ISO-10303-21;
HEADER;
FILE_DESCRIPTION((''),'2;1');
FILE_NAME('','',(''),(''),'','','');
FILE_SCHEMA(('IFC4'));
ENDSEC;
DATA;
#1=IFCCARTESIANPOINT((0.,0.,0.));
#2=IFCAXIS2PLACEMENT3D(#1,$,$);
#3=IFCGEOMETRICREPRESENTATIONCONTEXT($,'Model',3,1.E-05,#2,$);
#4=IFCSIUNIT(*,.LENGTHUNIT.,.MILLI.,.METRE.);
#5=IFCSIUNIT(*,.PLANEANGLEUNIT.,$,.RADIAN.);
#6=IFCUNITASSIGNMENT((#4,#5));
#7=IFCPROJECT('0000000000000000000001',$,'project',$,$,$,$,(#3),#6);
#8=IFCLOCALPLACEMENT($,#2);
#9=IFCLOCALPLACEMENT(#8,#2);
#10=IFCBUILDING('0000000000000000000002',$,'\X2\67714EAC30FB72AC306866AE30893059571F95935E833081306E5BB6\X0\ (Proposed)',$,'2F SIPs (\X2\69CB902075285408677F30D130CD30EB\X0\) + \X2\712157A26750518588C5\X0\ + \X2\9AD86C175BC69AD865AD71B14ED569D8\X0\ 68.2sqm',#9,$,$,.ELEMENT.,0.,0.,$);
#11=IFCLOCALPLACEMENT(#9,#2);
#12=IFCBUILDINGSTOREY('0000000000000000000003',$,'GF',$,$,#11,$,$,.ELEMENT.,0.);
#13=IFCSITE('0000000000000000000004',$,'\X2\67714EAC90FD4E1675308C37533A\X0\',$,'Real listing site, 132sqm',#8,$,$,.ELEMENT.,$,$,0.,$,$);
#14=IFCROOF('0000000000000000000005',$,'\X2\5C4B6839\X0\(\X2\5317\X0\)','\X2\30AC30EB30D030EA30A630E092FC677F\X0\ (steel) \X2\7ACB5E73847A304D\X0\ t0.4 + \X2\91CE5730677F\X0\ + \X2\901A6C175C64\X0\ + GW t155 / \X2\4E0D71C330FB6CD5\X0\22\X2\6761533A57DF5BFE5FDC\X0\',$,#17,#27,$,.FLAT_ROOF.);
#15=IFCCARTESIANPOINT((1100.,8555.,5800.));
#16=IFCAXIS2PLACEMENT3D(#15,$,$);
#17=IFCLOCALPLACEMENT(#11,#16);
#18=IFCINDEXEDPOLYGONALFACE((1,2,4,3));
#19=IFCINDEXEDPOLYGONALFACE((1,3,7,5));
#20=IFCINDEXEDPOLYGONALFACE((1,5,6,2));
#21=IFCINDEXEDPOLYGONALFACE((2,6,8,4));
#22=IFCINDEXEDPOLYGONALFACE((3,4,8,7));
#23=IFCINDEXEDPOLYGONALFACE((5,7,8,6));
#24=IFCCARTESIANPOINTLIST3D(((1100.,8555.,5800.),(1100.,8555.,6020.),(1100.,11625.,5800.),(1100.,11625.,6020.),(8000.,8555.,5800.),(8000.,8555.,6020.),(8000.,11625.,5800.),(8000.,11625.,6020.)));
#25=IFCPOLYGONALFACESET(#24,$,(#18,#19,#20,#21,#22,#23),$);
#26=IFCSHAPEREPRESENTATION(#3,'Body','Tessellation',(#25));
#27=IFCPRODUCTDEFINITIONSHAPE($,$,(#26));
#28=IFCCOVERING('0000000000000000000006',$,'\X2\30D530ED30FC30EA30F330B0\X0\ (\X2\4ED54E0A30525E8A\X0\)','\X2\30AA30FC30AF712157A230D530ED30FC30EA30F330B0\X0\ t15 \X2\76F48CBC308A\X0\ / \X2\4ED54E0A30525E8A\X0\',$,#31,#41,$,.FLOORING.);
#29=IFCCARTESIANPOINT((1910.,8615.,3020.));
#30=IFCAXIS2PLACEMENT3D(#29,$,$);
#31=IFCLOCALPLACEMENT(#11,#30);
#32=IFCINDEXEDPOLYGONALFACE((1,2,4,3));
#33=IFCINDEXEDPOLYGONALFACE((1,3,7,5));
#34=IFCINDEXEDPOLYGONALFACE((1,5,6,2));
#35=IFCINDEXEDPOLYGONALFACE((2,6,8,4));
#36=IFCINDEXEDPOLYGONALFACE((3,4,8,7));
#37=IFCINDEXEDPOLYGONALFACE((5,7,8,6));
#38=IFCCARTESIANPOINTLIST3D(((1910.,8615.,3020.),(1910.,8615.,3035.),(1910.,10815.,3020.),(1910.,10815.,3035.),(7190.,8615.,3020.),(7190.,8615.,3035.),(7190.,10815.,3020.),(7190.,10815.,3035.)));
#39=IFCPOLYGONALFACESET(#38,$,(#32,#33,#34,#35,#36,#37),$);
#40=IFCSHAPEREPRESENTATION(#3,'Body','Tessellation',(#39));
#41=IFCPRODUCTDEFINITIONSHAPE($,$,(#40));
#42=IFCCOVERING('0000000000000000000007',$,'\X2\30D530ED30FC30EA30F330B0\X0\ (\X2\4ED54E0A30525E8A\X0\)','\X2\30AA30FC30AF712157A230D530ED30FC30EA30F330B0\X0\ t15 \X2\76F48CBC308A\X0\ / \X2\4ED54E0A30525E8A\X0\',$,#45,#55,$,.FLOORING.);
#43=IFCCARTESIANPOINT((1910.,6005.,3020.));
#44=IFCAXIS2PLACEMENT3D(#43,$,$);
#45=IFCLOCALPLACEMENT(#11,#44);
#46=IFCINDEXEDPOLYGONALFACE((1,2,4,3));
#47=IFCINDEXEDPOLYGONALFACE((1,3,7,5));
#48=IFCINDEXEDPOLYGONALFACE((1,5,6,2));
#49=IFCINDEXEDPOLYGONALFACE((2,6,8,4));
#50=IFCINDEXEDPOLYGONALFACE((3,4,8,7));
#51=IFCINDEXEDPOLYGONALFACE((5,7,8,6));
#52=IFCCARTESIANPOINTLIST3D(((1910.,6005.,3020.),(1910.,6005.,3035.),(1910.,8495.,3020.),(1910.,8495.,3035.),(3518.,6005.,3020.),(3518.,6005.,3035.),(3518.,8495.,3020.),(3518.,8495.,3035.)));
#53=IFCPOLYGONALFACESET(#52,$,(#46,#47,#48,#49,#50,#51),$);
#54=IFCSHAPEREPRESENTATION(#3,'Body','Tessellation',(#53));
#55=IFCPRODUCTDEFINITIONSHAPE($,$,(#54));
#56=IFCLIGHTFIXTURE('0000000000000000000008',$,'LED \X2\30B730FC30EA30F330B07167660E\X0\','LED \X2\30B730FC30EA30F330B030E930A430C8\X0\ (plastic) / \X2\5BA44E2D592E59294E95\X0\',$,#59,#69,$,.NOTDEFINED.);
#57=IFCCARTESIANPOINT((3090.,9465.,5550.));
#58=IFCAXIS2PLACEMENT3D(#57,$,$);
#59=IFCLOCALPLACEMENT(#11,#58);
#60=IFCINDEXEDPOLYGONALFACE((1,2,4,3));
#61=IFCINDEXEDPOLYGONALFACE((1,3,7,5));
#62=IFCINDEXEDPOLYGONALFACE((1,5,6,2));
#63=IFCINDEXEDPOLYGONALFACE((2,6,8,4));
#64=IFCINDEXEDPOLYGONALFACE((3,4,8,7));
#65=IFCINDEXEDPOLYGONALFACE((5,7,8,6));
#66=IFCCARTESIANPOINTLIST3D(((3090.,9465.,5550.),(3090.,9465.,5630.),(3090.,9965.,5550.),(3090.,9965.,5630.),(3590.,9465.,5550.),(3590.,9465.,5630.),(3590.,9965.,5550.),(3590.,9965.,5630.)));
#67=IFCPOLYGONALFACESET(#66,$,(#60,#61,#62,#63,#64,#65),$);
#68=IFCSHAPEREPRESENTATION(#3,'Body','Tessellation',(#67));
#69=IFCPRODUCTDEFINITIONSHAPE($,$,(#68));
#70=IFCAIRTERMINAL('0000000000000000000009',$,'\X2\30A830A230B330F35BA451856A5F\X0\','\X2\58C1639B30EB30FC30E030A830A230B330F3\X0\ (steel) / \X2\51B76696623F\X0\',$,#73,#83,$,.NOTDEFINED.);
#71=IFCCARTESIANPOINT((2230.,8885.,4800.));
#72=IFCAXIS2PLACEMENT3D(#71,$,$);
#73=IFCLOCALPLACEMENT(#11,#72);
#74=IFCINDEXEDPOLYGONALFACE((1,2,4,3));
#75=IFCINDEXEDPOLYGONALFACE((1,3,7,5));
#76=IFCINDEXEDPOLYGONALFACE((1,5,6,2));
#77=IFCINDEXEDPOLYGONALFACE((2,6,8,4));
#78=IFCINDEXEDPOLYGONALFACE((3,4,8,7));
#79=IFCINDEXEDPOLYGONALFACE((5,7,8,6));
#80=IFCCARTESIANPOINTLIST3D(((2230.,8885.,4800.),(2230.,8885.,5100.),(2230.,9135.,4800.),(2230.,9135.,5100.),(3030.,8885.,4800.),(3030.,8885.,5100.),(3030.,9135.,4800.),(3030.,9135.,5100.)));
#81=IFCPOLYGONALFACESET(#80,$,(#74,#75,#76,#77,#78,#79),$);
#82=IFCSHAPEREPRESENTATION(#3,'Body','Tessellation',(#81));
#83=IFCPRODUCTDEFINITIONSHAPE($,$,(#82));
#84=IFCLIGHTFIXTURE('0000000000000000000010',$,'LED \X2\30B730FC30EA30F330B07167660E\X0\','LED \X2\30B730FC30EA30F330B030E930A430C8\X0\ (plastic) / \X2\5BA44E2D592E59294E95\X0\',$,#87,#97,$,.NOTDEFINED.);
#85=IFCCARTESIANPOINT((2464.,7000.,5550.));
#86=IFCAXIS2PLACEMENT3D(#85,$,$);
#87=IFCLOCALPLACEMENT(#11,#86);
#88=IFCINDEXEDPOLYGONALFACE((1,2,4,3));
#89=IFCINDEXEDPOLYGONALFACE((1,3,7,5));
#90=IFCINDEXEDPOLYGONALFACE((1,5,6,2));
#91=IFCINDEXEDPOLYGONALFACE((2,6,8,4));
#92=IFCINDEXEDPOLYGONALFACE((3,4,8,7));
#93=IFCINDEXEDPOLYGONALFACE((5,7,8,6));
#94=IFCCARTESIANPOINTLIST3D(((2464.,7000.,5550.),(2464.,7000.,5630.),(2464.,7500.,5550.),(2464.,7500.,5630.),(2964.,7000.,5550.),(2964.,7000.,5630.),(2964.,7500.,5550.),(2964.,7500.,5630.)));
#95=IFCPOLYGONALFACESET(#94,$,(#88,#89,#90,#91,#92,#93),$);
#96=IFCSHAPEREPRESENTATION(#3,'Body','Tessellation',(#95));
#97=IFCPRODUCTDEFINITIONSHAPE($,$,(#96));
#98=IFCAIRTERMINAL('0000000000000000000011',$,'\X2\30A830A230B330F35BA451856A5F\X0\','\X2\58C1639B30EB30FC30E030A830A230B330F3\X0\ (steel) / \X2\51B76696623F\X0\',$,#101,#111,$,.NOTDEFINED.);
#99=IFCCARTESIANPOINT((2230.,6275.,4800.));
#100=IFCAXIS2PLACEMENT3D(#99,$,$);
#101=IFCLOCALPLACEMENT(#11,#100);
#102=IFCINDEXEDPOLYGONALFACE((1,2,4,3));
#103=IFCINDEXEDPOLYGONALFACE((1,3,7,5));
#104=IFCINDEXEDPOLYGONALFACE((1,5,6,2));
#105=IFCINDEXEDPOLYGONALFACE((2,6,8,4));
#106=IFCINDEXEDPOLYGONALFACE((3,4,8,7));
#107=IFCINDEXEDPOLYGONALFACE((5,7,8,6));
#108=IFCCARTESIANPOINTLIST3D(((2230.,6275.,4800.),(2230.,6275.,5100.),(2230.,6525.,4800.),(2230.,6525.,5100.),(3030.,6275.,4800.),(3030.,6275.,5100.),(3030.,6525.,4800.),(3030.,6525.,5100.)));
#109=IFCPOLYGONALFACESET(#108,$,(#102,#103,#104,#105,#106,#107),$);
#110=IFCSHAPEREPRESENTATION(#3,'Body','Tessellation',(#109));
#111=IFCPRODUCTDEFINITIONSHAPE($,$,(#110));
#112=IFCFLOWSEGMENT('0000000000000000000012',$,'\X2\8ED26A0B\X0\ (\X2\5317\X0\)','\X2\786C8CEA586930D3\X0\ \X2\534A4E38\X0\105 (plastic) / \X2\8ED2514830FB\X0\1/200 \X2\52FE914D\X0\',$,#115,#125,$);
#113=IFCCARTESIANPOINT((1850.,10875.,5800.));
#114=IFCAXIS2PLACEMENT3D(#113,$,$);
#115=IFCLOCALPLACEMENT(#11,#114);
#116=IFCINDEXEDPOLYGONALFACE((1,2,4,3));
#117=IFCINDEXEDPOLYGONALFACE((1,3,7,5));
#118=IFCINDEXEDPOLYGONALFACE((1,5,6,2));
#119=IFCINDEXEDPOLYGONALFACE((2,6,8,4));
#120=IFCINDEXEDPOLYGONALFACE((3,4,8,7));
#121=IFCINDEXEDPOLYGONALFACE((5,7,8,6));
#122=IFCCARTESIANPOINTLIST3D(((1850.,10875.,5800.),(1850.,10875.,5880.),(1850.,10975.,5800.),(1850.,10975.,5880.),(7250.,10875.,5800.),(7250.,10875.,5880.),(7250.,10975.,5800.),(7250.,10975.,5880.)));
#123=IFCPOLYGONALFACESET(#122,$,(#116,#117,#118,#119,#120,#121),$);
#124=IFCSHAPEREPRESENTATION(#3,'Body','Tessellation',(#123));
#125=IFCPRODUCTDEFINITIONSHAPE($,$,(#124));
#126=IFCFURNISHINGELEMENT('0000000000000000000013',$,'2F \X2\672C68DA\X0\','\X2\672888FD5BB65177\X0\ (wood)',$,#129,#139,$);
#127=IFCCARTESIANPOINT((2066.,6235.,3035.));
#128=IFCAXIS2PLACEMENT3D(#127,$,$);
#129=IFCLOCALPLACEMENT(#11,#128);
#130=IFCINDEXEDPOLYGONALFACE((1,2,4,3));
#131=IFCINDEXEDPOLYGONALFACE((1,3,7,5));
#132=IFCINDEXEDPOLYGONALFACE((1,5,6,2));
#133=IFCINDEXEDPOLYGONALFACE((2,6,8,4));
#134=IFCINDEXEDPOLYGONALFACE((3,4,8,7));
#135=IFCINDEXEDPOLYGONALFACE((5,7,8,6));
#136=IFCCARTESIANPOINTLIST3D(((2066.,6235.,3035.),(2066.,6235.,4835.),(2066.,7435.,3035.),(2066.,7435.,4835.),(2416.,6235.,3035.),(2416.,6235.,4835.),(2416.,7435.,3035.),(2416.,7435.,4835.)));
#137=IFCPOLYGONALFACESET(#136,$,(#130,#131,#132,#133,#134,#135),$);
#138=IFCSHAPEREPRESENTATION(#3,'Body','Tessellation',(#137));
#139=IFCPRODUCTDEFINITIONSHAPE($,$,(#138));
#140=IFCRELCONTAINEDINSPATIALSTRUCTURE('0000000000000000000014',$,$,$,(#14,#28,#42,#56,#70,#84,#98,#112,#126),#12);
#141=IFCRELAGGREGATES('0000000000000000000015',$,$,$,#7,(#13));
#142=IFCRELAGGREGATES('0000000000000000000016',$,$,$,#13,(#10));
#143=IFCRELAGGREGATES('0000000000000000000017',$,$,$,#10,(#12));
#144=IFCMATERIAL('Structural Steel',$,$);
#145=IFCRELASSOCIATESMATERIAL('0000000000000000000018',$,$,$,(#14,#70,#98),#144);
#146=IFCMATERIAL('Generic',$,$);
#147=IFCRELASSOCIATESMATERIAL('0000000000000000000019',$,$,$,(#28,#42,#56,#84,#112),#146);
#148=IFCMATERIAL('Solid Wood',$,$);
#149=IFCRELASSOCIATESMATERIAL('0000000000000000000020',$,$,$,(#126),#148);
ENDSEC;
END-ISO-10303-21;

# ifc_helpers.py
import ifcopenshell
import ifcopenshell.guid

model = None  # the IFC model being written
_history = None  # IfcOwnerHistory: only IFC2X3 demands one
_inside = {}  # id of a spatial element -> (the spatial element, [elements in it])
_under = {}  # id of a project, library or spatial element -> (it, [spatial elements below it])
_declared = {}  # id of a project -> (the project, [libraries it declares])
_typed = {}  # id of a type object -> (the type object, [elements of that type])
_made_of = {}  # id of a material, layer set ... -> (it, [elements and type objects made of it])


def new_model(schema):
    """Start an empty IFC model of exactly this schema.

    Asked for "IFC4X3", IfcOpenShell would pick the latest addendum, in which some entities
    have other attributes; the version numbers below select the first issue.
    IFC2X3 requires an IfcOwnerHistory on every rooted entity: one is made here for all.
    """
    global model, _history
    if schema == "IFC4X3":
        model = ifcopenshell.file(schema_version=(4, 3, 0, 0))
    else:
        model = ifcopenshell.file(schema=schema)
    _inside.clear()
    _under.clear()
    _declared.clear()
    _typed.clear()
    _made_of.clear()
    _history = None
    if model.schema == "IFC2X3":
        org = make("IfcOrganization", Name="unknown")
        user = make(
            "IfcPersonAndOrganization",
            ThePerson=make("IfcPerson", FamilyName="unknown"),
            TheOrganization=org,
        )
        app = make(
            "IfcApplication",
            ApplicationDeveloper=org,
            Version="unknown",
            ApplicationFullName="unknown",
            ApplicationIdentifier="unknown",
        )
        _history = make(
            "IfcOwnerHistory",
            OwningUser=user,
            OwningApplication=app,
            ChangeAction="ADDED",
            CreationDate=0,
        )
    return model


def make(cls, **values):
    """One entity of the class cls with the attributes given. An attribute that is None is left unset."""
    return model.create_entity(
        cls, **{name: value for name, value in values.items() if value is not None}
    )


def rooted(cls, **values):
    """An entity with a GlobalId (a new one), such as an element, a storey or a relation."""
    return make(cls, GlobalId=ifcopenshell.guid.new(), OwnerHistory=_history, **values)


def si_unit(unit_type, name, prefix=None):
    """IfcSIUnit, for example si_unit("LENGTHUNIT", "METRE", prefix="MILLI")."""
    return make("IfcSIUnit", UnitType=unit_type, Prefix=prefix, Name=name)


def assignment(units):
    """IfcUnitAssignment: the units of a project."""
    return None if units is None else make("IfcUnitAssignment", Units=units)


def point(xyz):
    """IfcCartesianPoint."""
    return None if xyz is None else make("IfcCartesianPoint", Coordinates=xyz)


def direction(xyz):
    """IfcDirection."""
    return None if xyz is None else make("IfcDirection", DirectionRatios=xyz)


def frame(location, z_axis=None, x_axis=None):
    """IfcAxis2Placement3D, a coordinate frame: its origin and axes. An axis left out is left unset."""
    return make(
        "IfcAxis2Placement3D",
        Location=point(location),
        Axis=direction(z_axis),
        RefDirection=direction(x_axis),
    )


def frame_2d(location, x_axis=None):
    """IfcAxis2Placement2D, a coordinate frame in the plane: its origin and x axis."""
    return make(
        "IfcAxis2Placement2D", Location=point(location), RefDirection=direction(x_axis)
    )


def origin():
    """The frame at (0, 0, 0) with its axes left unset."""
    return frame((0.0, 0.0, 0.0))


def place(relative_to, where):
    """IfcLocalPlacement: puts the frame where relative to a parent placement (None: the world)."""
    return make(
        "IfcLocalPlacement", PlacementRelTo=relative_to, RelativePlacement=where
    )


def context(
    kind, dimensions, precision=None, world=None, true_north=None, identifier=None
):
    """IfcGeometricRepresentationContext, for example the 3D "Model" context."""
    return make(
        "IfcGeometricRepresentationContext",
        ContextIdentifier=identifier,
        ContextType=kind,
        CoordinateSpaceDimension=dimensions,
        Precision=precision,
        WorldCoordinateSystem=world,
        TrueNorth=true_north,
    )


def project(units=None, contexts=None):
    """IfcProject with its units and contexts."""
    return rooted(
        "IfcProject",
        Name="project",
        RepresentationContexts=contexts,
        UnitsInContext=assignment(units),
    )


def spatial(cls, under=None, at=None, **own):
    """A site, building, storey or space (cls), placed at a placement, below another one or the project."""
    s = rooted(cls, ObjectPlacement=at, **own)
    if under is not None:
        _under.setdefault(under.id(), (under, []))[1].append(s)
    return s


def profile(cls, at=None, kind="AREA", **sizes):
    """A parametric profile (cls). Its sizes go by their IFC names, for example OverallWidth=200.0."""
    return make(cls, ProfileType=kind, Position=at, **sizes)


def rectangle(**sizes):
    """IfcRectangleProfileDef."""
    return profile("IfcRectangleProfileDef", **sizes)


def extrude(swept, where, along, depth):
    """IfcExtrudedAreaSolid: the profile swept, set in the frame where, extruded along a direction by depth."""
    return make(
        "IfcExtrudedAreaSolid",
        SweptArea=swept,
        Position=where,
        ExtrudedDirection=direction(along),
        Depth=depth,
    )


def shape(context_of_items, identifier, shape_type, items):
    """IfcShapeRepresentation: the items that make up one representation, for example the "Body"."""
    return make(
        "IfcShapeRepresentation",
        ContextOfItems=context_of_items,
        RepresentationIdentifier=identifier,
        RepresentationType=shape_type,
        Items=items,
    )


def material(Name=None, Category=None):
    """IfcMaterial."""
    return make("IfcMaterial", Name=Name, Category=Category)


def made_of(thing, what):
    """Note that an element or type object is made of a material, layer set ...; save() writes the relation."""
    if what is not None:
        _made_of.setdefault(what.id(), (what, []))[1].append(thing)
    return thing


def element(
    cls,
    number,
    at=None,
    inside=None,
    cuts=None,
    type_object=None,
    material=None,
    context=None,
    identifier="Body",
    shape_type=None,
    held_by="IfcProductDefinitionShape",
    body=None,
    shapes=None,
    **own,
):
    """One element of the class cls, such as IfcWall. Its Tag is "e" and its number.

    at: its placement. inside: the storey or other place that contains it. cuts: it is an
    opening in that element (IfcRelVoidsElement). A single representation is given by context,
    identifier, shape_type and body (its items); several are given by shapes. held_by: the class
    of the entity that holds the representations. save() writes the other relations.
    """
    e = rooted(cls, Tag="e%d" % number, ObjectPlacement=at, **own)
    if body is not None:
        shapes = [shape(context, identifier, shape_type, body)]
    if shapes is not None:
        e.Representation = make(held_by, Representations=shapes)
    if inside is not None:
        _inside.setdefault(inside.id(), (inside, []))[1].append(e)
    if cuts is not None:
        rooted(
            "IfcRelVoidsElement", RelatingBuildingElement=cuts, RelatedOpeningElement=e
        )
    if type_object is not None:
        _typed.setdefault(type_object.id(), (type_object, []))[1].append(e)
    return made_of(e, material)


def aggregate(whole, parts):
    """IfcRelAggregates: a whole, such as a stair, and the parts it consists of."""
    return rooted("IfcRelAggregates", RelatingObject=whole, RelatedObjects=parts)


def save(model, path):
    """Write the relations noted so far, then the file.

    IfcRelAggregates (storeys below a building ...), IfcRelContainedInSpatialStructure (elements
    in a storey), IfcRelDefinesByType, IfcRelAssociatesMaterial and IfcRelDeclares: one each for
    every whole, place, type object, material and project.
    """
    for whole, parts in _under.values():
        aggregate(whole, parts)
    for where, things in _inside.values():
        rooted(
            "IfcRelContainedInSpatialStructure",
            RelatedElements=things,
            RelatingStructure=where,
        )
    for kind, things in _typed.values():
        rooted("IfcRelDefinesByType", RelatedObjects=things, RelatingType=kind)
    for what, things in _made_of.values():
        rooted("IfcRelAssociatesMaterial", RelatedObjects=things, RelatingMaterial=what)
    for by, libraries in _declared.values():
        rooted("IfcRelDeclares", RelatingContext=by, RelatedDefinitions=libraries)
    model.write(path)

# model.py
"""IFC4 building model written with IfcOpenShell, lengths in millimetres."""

from ifc_helpers import new_model, si_unit, frame, frame_2d, origin, place, context, project, spatial, rectangle, extrude, material, element, save


model = new_model("IFC4")

# Units and contexts
model_context = context("Model", 3, precision=1e-05, world=origin())
ifc_project = project(units=[si_unit("LENGTHUNIT", "METRE", prefix="MILLI"), si_unit("PLANEANGLEUNIT", "RADIAN")], contexts=[model_context])

# Site, building, storey
site_placement = place(None, origin())
site = spatial("IfcSite", under=ifc_project, at=site_placement, Name="東京都世田谷区", ObjectType="Real listing site, 132sqm", CompositionType="ELEMENT", RefElevation=0.0)
building_placement = place(site_placement, origin())
building = spatial("IfcBuilding", under=site, at=building_placement, Name="東京・犬と暮らす土間広めの家 (Proposed)", ObjectType="2F SIPs (構造用合板パネル) + 無垢材内装 + 高気密高断熱仕様 68.2sqm", CompositionType="ELEMENT", ElevationOfRefHeight=0.0, ElevationOfTerrain=0.0)
storey_placement = place(building_placement, origin())
storey = spatial("IfcBuildingStorey", under=building, at=storey_placement, Name="GF", CompositionType="ELEMENT", Elevation=0.0)

# Shared definitions
ifc_material_1 = material(Name="Solid Wood")

# Roof
ifc_material_2 = material(Name="Structural Steel")
for number, where, name in (
    (1, (1100.0, 8555.0, 5800.0), "屋根(北)"),
):
    element("IfcRoof", number, at=place(storey_placement, frame(where)), inside=storey, material=ifc_material_2, Name=name, Description="ガルバリウム鋼板 (steel) 立平葺き t0.4 + 野地板 + 通気層 + GW t155 / 不燃・法22条区域対応", PredefinedType="FLAT_ROOF", context=model_context, shape_type="SweptSolid", body=[
        extrude(rectangle(XDim=6900.0, YDim=3070.0, at=frame_2d((3450.0, 1535.0))), frame((1100.0, 8555.0, 5800.0)), (0.0, 0.0, 1.0), 220.0),
    ])

# Coverings
ifc_material_3 = material(Name="Generic")
covering_1_placement = place(storey_placement, frame((1910.0, 8615.0, 3020.0)))
element("IfcCovering", 2, at=covering_1_placement, inside=storey, material=ifc_material_3, Name="フローリング (仕上げ床)", Description="オーク無垢フローリング t15 直貼り / 仕上げ床", PredefinedType="FLOORING", context=model_context, shape_type="SweptSolid", body=[
    extrude(rectangle(XDim=5280.0, YDim=2200.0, at=frame_2d((2640.0, 1100.0))), frame((1910.0, 8615.0, 3020.0)), (0.0, 0.0, 1.0), 15.0),
])
covering_2_placement = place(storey_placement, frame((1910.0, 6005.0, 3020.0)))
element("IfcCovering", 3, at=covering_2_placement, inside=storey, material=ifc_material_3, Name="フローリング (仕上げ床)", Description="オーク無垢フローリング t15 直貼り / 仕上げ床", PredefinedType="FLOORING", context=model_context, shape_type="SweptSolid", body=[
    extrude(rectangle(XDim=1608.0, YDim=2490.0, at=frame_2d((804.0, 1245.0))), frame((1910.0, 6005.0, 3020.0)), (0.0, 0.0, 1.0), 15.0),
])

# Light fixture
light_fixture_1_placement = place(storey_placement, frame((3090.0, 9465.0, 5550.0)))
element("IfcLightFixture", 4, at=light_fixture_1_placement, inside=storey, material=ifc_material_3, Name="LED シーリング照明", Description="LED シーリングライト (plastic) / 室中央天井", PredefinedType="NOTDEFINED", context=model_context, shape_type="SweptSolid", body=[
    extrude(rectangle(XDim=500.0, YDim=500.0, at=frame_2d((250.0, 250.0))), frame((3090.0, 9465.0, 5550.0)), (0.0, 0.0, 1.0), 80.0),
])

# Air terminal
air_terminal_1_placement = place(storey_placement, frame((2230.0, 8885.0, 4800.0)))
element("IfcAirTerminal", 5, at=air_terminal_1_placement, inside=storey, material=ifc_material_2, Name="エアコン室内機", Description="壁掛ルームエアコン (steel) / 冷暖房", PredefinedType="NOTDEFINED", context=model_context, shape_type="SweptSolid", body=[
    extrude(rectangle(XDim=800.0, YDim=250.0, at=frame_2d((400.0, 125.0))), frame((2230.0, 8885.0, 4800.0)), (0.0, 0.0, 1.0), 300.0),
])

# Light fixture
light_fixture_2_placement = place(storey_placement, frame((2464.0, 7000.0, 5550.0)))
element("IfcLightFixture", 6, at=light_fixture_2_placement, inside=storey, material=ifc_material_3, Name="LED シーリング照明", Description="LED シーリングライト (plastic) / 室中央天井", PredefinedType="NOTDEFINED", context=model_context, shape_type="SweptSolid", body=[
    extrude(rectangle(XDim=500.0, YDim=500.0, at=frame_2d((250.0, 250.0))), frame((2464.0, 7000.0, 5550.0)), (0.0, 0.0, 1.0), 80.0),
])

# Air terminal
air_terminal_2_placement = place(storey_placement, frame((2230.0, 6275.0, 4800.0)))
element("IfcAirTerminal", 7, at=air_terminal_2_placement, inside=storey, material=ifc_material_2, Name="エアコン室内機", Description="壁掛ルームエアコン (steel) / 冷暖房", PredefinedType="NOTDEFINED", context=model_context, shape_type="SweptSolid", body=[
    extrude(rectangle(XDim=800.0, YDim=250.0, at=frame_2d((400.0, 125.0))), frame((2230.0, 6275.0, 4800.0)), (0.0, 0.0, 1.0), 300.0),
])

# Flow segment
flow_segment_placement = place(storey_placement, frame((1850.0, 10875.0, 5800.0)))
element("IfcFlowSegment", 8, at=flow_segment_placement, inside=storey, material=ifc_material_3, Name="軒樋 (北)", Description="硬質塩ビ 半丸105 (plastic) / 軒先・1/200 勾配", context=model_context, shape_type="SweptSolid", body=[
    extrude(rectangle(XDim=5400.0, YDim=100.0, at=frame_2d((2700.0, 50.0))), frame((1850.0, 10875.0, 5800.0)), (0.0, 0.0, 1.0), 80.0),
])

# Furnishing element
furnishing_placement = place(storey_placement, frame((2066.0, 6235.0, 3035.0)))
element("IfcFurnishingElement", 9, at=furnishing_placement, inside=storey, material=ifc_material_1, Name="2F 本棚", Description="木製家具 (wood)", context=model_context, shape_type="SweptSolid", body=[
    extrude(rectangle(XDim=350.0, YDim=1200.0, at=frame_2d((175.0, 600.0))), frame((2066.0, 6235.0, 3035.0)), (0.0, 0.0, 1.0), 1800.0),
])

save(model, "model.ifc")
